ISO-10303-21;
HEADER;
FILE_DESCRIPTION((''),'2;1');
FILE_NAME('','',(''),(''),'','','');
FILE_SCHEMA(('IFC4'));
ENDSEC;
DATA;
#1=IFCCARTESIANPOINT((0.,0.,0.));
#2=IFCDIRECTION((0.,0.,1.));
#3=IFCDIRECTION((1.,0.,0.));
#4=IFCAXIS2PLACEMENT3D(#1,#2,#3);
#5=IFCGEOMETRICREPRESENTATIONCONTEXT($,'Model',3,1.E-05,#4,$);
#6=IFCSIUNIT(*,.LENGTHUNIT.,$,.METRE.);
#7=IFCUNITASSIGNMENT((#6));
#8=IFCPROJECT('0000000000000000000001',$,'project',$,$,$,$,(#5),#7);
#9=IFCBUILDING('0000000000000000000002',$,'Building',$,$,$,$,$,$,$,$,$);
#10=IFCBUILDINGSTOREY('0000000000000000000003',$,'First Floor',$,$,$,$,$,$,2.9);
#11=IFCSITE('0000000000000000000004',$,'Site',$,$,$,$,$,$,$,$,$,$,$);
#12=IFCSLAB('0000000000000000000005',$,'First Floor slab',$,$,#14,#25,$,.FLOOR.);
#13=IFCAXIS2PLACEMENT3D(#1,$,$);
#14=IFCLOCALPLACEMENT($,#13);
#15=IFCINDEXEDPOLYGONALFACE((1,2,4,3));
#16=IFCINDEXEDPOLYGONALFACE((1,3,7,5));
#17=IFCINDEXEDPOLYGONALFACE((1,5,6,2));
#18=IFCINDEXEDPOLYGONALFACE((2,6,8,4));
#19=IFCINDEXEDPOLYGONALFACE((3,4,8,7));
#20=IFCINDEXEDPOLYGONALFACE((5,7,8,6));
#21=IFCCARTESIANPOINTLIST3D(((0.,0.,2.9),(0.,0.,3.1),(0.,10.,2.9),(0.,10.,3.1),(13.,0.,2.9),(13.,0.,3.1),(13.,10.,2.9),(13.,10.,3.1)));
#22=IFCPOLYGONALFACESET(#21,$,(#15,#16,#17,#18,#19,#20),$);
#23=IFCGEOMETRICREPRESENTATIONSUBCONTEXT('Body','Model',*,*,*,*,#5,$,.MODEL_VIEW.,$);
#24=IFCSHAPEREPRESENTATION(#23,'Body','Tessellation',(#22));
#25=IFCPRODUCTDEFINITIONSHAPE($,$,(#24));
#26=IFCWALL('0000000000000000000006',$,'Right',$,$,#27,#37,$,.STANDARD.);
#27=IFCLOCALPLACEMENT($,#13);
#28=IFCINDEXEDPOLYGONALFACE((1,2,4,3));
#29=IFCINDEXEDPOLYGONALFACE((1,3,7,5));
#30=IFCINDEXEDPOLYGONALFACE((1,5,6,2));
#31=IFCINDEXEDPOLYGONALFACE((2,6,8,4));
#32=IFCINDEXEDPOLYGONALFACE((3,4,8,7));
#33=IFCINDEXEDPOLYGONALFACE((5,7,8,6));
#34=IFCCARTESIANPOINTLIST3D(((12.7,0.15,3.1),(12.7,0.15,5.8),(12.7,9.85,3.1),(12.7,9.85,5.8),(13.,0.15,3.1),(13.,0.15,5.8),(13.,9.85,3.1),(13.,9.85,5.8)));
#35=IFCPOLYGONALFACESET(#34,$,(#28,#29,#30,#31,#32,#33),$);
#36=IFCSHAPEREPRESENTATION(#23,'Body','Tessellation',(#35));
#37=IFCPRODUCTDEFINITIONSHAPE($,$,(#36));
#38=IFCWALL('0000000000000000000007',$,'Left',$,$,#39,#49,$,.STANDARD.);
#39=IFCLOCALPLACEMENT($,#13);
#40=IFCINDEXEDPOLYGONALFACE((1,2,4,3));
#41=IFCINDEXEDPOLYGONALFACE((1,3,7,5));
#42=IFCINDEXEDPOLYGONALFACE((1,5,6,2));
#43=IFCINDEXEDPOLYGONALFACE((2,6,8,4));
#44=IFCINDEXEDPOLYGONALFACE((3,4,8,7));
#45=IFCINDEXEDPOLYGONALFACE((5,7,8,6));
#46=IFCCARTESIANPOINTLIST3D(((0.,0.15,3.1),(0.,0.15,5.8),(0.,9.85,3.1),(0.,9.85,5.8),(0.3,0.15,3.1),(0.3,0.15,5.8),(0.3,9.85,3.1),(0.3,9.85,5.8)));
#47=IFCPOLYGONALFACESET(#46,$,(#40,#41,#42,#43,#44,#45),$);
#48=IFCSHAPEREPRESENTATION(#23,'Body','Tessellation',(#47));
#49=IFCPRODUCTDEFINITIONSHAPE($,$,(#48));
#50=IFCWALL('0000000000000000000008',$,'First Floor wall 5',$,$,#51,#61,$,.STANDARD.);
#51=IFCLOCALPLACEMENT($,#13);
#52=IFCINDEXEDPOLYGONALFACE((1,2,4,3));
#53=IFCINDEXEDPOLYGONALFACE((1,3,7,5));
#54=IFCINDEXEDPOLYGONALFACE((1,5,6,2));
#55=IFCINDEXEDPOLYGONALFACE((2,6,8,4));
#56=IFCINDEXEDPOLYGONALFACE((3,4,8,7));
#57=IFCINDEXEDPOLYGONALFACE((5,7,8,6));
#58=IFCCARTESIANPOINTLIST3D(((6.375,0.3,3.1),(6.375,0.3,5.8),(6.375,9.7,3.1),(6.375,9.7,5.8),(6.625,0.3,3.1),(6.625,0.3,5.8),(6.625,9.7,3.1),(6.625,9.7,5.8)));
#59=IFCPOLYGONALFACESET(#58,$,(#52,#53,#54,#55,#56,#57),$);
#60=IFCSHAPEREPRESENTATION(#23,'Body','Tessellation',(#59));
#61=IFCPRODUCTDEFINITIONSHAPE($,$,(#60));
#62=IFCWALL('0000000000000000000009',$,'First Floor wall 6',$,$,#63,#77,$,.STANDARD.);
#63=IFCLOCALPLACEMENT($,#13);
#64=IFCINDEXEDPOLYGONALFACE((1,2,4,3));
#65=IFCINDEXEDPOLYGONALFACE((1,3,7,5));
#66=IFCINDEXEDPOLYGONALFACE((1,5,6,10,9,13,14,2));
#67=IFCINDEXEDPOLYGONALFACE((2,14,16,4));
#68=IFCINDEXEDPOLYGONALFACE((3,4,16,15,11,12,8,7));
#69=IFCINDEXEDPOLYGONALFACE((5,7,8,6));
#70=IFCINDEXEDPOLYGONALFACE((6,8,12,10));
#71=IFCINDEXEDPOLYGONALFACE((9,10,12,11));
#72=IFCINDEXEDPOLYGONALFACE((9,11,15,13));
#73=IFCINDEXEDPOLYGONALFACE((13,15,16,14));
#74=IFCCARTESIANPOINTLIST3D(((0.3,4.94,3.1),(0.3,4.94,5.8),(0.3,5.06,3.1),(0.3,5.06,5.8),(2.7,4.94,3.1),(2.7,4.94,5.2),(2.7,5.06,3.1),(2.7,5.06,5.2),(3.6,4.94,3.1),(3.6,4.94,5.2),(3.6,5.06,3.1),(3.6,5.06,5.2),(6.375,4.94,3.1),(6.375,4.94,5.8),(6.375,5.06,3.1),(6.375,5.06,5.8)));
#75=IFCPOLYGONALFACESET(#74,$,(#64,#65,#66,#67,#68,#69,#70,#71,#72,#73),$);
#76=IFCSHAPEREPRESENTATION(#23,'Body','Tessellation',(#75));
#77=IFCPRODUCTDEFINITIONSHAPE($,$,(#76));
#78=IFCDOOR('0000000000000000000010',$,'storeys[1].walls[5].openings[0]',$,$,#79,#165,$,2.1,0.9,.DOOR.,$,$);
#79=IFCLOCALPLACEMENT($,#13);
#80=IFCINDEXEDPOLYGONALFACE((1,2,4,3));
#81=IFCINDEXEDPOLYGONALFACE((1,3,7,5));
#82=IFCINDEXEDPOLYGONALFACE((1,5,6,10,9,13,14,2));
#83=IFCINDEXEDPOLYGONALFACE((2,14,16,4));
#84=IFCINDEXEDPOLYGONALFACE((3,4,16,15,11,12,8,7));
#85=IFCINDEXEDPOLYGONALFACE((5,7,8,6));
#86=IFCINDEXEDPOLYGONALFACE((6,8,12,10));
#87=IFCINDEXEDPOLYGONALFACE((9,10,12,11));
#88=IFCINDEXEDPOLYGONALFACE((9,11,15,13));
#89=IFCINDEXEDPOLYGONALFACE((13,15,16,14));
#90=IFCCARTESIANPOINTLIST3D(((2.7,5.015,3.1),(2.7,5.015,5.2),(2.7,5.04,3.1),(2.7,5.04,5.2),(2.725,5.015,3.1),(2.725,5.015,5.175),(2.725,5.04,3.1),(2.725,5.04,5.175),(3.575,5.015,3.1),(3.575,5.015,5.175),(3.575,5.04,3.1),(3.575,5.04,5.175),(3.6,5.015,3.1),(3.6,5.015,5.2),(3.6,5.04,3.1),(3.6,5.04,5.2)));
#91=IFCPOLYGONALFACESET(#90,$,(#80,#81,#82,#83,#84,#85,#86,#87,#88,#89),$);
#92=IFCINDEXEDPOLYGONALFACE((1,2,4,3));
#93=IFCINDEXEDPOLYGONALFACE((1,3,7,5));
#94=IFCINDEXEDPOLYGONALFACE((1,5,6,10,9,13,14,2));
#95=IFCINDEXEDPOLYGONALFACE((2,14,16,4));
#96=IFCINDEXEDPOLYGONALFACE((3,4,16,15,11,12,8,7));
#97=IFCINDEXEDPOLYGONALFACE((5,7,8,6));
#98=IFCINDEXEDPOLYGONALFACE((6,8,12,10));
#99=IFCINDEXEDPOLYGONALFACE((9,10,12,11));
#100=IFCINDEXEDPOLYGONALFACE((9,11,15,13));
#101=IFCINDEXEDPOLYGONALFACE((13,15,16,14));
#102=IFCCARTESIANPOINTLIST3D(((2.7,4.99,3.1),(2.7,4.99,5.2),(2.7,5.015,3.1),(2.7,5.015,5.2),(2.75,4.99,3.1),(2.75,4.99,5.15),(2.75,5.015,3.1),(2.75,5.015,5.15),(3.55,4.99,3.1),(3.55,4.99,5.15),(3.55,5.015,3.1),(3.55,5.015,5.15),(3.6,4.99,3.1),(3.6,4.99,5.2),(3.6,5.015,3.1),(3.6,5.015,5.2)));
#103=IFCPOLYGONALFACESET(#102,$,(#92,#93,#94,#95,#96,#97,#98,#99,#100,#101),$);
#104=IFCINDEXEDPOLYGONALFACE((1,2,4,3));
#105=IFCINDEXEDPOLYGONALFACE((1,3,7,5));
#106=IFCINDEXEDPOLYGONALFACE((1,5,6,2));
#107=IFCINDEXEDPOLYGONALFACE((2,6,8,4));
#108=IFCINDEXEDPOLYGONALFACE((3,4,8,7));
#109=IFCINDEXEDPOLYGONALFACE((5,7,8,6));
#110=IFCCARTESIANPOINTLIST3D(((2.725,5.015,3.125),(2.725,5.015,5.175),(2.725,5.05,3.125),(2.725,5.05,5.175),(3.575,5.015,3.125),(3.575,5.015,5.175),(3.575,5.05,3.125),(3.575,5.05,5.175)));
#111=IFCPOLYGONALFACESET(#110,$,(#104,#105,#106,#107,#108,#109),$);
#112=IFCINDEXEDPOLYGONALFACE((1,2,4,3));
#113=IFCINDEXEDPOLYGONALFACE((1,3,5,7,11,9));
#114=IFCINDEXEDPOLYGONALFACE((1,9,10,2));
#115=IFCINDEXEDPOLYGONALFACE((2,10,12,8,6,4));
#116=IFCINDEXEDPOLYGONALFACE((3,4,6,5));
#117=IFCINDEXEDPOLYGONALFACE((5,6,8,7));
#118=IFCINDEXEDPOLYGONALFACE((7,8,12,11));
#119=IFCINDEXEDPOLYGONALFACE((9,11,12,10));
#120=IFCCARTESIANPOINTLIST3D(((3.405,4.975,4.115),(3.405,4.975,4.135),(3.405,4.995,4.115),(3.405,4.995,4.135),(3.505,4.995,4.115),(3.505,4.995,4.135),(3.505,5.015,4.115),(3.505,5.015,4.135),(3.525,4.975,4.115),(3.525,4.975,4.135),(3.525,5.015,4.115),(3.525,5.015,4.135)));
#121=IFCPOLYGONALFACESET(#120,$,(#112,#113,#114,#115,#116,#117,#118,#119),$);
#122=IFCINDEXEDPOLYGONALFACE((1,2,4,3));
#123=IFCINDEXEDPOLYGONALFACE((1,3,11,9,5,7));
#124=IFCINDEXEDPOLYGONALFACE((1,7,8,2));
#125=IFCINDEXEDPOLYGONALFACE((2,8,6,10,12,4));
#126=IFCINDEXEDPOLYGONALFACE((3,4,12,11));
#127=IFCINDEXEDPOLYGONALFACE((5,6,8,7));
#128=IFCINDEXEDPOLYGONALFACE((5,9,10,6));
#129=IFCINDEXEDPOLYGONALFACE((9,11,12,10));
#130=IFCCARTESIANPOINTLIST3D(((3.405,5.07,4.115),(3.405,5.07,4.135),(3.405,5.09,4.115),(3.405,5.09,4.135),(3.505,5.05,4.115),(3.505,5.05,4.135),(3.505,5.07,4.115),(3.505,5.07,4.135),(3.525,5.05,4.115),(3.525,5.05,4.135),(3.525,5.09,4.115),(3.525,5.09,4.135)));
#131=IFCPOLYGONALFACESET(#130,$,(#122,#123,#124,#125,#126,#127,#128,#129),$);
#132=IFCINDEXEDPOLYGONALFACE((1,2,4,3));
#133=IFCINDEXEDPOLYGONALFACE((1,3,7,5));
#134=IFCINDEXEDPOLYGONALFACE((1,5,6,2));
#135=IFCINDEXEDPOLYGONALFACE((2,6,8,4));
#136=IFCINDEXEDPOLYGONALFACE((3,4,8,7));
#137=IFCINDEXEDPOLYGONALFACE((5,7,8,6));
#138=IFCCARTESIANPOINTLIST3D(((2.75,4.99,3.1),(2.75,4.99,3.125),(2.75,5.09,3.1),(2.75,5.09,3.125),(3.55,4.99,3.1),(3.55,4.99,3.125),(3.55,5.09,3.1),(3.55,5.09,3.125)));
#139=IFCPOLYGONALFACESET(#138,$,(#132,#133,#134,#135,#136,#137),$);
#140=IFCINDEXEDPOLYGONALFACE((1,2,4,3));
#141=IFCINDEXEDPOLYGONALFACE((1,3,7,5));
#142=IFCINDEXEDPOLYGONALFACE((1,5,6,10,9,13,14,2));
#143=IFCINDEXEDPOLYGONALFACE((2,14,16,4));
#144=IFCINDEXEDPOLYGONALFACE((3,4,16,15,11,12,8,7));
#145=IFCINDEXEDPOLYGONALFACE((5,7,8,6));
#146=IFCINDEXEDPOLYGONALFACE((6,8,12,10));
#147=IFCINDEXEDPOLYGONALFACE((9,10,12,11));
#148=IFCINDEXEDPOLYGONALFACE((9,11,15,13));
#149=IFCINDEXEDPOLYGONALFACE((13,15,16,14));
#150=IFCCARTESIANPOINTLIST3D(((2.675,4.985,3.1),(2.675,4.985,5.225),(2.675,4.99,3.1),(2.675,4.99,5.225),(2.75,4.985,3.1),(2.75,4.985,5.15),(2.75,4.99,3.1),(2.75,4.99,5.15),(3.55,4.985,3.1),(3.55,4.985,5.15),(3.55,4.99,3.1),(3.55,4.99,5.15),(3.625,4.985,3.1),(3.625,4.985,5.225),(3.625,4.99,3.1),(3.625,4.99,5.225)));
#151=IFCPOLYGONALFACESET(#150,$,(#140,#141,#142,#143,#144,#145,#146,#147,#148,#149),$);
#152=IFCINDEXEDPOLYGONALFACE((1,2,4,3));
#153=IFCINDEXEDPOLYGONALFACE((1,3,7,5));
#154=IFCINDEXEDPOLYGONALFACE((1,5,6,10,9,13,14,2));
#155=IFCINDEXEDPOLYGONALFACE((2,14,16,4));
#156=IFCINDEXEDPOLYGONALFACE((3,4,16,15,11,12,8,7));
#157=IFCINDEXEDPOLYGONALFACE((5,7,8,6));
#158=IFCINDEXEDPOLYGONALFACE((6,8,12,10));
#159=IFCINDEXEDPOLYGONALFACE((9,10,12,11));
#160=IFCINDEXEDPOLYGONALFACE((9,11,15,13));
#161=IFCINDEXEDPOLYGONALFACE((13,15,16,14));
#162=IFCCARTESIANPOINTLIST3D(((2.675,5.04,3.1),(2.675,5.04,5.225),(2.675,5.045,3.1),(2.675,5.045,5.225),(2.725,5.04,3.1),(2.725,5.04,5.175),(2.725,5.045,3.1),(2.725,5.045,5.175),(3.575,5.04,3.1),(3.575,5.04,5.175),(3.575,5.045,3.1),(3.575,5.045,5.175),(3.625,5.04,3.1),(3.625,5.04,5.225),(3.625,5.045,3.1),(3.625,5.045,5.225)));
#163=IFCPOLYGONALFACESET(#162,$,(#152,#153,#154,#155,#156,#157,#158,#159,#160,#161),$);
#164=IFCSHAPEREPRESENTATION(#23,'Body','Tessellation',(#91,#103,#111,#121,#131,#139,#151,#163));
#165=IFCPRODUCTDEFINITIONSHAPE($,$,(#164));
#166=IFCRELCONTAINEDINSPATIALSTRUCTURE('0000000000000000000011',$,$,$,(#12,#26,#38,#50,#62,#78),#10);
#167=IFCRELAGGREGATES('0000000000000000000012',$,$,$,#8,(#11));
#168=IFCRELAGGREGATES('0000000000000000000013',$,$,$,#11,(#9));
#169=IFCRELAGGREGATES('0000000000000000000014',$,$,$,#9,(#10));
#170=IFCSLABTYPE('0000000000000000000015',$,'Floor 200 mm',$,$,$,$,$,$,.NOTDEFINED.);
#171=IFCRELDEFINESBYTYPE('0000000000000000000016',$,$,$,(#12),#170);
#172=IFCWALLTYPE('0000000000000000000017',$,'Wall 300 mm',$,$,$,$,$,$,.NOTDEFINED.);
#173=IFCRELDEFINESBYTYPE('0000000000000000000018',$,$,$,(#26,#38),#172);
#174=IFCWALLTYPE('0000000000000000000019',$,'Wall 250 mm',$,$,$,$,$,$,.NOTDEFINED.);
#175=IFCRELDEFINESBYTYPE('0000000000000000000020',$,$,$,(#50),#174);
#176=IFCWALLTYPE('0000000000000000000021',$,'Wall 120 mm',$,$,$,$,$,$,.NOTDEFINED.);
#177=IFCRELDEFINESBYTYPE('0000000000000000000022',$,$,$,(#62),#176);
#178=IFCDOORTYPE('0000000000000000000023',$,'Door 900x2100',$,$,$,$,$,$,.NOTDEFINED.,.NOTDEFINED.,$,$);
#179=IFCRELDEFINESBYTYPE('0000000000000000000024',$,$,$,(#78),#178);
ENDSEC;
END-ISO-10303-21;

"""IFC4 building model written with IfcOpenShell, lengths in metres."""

from ifc_helpers import new_model, si_unit, frame, origin_with_axes, place, context, subcontext, project, spatial, line, indexed_curve, outline, extrude, type_object, element, fill, save


model = new_model("IFC4")

# Units and contexts
model_context = context("Model", 3, precision=1e-05, world=origin_with_axes())
body_context = subcontext(model_context, "Body", "Model", "MODEL_VIEW")
ifc_project = project(units=[si_unit("LENGTHUNIT", "METRE")], contexts=[model_context])

# Site, building, storey
site = spatial("IfcSite", under=ifc_project, Name="Site")
building = spatial("IfcBuilding", under=site, Name="Building")
storey = spatial("IfcBuildingStorey", under=building, Name="First Floor", Elevation=2.9)

# Slab
slab_type = type_object("IfcSlabType", Name="Floor 200 mm", PredefinedType="NOTDEFINED")
slab_placement = place(None, frame((0.0, 0.0, 2.9), z_axis=(0.0, 0.0, 1.0), x_axis=(1.0, 0.0, 0.0)))
element("IfcSlab", 1, at=slab_placement, inside=storey, type_object=slab_type, Name="First Floor slab", PredefinedType="FLOOR", context=body_context, shape_type="SweptSolid", body=[
    extrude(outline(indexed_curve([(0.0, 0.0), (13.0, 0.0), (13.0, 10.0), (0.0, 10.0)])), None, (0.0, 0.0, 1.0), 0.2),
])

# Shared definitions
wall_type_1 = type_object("IfcWallType", Name="Wall 300 mm", PredefinedType="NOTDEFINED")

# Wall
wall_1_placement = place(None, frame((12.85, 0.15, 3.1), z_axis=(0.0, 0.0, 1.0), x_axis=(0.0, 1.0, 0.0)))
element("IfcWall", 2, at=wall_1_placement, inside=storey, type_object=wall_type_1, Name="Right", PredefinedType="STANDARD", context=body_context, shape_type="SweptSolid", body=[
    extrude(outline(indexed_curve([(0.0, 0.0), (0.0, 0.3), (9.7, 0.3), (9.7, 0.0), (0.0, 0.0)], self_intersect=False)), frame((0.0, -0.15, 0.0), z_axis=(0.0, 0.0, 1.0), x_axis=(1.0, 0.0, 0.0)), (0.0, 0.0, 1.0), 2.7),
])

# Walls
wall_2_placement = place(None, frame((0.15, 9.85, 3.1), z_axis=(0.0, 0.0, 1.0), x_axis=(0.0, -1.0, 0.0)))
element("IfcWall", 3, at=wall_2_placement, inside=storey, type_object=wall_type_1, Name="Left", PredefinedType="STANDARD", context=body_context, shape_type="SweptSolid", body=[
    extrude(outline(indexed_curve([(0.0, 0.0), (0.0, 0.3), (9.7, 0.3), (9.7, 0.0), (0.0, 0.0)], self_intersect=False)), frame((0.0, -0.15, 0.0), z_axis=(0.0, 0.0, 1.0), x_axis=(1.0, 0.0, 0.0)), (0.0, 0.0, 1.0), 2.7),
])
wall_type_2 = type_object("IfcWallType", Name="Wall 250 mm", PredefinedType="NOTDEFINED")
wall_3_placement = place(None, frame((6.5, 0.3, 3.1), z_axis=(0.0, 0.0, 1.0), x_axis=(0.0, 1.0, 0.0)))
element("IfcWall", 4, at=wall_3_placement, inside=storey, type_object=wall_type_2, Name="First Floor wall 5", PredefinedType="STANDARD", context=body_context, shape_type="SweptSolid", body=[
    extrude(outline(indexed_curve([(0.0, 0.0), (0.0, 0.25), (9.4, 0.25), (9.4, 0.0), (0.0, 0.0)], self_intersect=False)), frame((0.0, -0.125, 0.0), z_axis=(0.0, 0.0, 1.0), x_axis=(1.0, 0.0, 0.0)), (0.0, 0.0, 1.0), 2.7),
])

# Wall, opening, door
wall_type_3 = type_object("IfcWallType", Name="Wall 120 mm", PredefinedType="NOTDEFINED")
wall_4_placement = place(None, frame((0.3, 5.0, 3.1), z_axis=(0.0, 0.0, 1.0), x_axis=(1.0, 0.0, 0.0)))
wall_4 = element("IfcWall", 5, at=wall_4_placement, inside=storey, type_object=wall_type_3, Name="First Floor wall 6", PredefinedType="STANDARD", context=body_context, shape_type="SweptSolid", body=[
    extrude(outline(indexed_curve([(0.0, 0.0), (0.0, 0.12), (6.075, 0.12), (6.075, 0.0), (0.0, 0.0)], self_intersect=False)), frame((0.0, -0.06, 0.0), z_axis=(0.0, 0.0, 1.0), x_axis=(1.0, 0.0, 0.0)), (0.0, 0.0, 1.0), 2.7),
])
opening_1_placement = place(wall_4_placement, frame((2.4, -0.07, 0.0), z_axis=(0.0, 0.0, 1.0), x_axis=(1.0, 0.0, 0.0)))
opening_1 = element("IfcOpeningElement", 6, at=opening_1_placement, cuts=wall_4, context=body_context, shape_type="SweptSolid", body=[
    extrude(outline(indexed_curve([(0.0, 0.0), (0.0, 0.14), (0.9, 0.14), (0.9, 0.0), (0.0, 0.0)], self_intersect=False)), origin_with_axes(), (0.0, 0.0, 1.0), 2.1),
])
door_type = type_object("IfcDoorType", Name="Door 900x2100", OperationType="NOTDEFINED", PredefinedType="NOTDEFINED")
door_1_placement = place(None, frame((2.7, 4.99, 3.1), z_axis=(0.0, 0.0, 1.0), x_axis=(1.0, 0.0, 0.0)))
door_1 = element("IfcDoor", 7, at=door_1_placement, inside=storey, type_object=door_type, Name="storeys[1].walls[5].openings[0]", OverallHeight=2.1, OverallWidth=0.9, PredefinedType="DOOR", context=body_context, shape_type="SweptSolid", body=[
    extrude(outline(indexed_curve([(0.0, 0.0), (0.0, 2.1), (0.9, 2.1), (0.9, 0.0), (0.875, 0.0), (0.875, 2.075), (0.025, 2.075), (0.025, 0.0)], segments=[line(1, 2, 3, 4, 5, 6, 7, 8, 1)])), frame((0.0, 0.025, 0.0), z_axis=(0.0, -1.0, 0.0), x_axis=(1.0, 0.0, 0.0)), (0.0, 0.0, -1.0), 0.025),
    extrude(outline(indexed_curve([(0.0, 0.0), (0.0, 2.1), (0.9, 2.1), (0.9, 0.0), (0.85, 0.0), (0.85, 2.05), (0.05, 2.05), (0.05, 0.0)], segments=[line(1, 2, 3, 4, 5, 6, 7, 8, 1)])), frame((0.0, 0.0, 0.0), z_axis=(0.0, -1.0, 0.0), x_axis=(1.0, 0.0, 0.0)), (0.0, 0.0, -1.0), 0.025),
    extrude(outline(indexed_curve([(0.0, 0.0), (0.85, 0.0), (0.85, 0.035), (0.0, 0.035)], segments=[line(1, 2, 3, 4, 1)])), frame((0.025, 0.025, 0.025), z_axis=(0.0, 0.0, 1.0), x_axis=(1.0, 0.0, 0.0)), (0.0, 0.0, 1.0), 2.05),
    extrude(outline(indexed_curve([(0.0, 0.0), (0.0, -0.04), (-0.12, -0.04), (-0.12, -0.02), (-0.02, -0.02), (-0.02, 0.0)], segments=[line(1, 2, 3, 4, 5, 6, 1)])), frame((0.825, 0.025, 1.015), z_axis=(0.0, 0.0, 1.0), x_axis=(1.0, 0.0, 0.0)), (0.0, 0.0, 1.0), 0.02),
    extrude(outline(indexed_curve([(0.0, 0.0), (0.0, 0.04), (-0.12, 0.04), (-0.12, 0.02), (-0.02, 0.02), (-0.02, 0.0)], segments=[line(1, 2, 3, 4, 5, 6, 1)])), frame((0.825, 0.06, 1.015), z_axis=(0.0, 0.0, 1.0), x_axis=(1.0, 0.0, 0.0)), (0.0, 0.0, 1.0), 0.02),
    extrude(outline(indexed_curve([(0.0, 0.0), (0.8, 0.0), (0.8, 0.1), (0.0, 0.1)], segments=[line(1, 2, 3, 4, 1)])), frame((0.05, 0.0, 0.0), z_axis=(0.0, 0.0, 1.0), x_axis=(1.0, 0.0, 0.0)), (0.0, 0.0, 1.0), 0.025),
    extrude(outline(indexed_curve([(0.0, 0.0), (0.0, 2.125), (0.95, 2.125), (0.95, 0.0), (0.875, 0.0), (0.875, 2.05), (0.075, 2.05), (0.075, 0.0)], segments=[line(1, 2, 3, 4, 5, 6, 7, 8, 1)])), frame((-0.025, -0.005, 0.0), z_axis=(0.0, -1.0, 0.0), x_axis=(1.0, 0.0, 0.0)), (0.0, 0.0, -1.0), 0.005),
    extrude(outline(indexed_curve([(0.0, 0.0), (0.0, 2.125), (0.95, 2.125), (0.95, 0.0), (0.9, 0.0), (0.9, 2.075), (0.05, 2.075), (0.05, 0.0)], segments=[line(1, 2, 3, 4, 5, 6, 7, 8, 1)])), frame((-0.025, 0.05, 0.0), z_axis=(0.0, -1.0, 0.0), x_axis=(1.0, 0.0, 0.0)), (0.0, 0.0, -1.0), 0.005),
])
fill(opening_1, door_1)

save(model, "model.ifc")
